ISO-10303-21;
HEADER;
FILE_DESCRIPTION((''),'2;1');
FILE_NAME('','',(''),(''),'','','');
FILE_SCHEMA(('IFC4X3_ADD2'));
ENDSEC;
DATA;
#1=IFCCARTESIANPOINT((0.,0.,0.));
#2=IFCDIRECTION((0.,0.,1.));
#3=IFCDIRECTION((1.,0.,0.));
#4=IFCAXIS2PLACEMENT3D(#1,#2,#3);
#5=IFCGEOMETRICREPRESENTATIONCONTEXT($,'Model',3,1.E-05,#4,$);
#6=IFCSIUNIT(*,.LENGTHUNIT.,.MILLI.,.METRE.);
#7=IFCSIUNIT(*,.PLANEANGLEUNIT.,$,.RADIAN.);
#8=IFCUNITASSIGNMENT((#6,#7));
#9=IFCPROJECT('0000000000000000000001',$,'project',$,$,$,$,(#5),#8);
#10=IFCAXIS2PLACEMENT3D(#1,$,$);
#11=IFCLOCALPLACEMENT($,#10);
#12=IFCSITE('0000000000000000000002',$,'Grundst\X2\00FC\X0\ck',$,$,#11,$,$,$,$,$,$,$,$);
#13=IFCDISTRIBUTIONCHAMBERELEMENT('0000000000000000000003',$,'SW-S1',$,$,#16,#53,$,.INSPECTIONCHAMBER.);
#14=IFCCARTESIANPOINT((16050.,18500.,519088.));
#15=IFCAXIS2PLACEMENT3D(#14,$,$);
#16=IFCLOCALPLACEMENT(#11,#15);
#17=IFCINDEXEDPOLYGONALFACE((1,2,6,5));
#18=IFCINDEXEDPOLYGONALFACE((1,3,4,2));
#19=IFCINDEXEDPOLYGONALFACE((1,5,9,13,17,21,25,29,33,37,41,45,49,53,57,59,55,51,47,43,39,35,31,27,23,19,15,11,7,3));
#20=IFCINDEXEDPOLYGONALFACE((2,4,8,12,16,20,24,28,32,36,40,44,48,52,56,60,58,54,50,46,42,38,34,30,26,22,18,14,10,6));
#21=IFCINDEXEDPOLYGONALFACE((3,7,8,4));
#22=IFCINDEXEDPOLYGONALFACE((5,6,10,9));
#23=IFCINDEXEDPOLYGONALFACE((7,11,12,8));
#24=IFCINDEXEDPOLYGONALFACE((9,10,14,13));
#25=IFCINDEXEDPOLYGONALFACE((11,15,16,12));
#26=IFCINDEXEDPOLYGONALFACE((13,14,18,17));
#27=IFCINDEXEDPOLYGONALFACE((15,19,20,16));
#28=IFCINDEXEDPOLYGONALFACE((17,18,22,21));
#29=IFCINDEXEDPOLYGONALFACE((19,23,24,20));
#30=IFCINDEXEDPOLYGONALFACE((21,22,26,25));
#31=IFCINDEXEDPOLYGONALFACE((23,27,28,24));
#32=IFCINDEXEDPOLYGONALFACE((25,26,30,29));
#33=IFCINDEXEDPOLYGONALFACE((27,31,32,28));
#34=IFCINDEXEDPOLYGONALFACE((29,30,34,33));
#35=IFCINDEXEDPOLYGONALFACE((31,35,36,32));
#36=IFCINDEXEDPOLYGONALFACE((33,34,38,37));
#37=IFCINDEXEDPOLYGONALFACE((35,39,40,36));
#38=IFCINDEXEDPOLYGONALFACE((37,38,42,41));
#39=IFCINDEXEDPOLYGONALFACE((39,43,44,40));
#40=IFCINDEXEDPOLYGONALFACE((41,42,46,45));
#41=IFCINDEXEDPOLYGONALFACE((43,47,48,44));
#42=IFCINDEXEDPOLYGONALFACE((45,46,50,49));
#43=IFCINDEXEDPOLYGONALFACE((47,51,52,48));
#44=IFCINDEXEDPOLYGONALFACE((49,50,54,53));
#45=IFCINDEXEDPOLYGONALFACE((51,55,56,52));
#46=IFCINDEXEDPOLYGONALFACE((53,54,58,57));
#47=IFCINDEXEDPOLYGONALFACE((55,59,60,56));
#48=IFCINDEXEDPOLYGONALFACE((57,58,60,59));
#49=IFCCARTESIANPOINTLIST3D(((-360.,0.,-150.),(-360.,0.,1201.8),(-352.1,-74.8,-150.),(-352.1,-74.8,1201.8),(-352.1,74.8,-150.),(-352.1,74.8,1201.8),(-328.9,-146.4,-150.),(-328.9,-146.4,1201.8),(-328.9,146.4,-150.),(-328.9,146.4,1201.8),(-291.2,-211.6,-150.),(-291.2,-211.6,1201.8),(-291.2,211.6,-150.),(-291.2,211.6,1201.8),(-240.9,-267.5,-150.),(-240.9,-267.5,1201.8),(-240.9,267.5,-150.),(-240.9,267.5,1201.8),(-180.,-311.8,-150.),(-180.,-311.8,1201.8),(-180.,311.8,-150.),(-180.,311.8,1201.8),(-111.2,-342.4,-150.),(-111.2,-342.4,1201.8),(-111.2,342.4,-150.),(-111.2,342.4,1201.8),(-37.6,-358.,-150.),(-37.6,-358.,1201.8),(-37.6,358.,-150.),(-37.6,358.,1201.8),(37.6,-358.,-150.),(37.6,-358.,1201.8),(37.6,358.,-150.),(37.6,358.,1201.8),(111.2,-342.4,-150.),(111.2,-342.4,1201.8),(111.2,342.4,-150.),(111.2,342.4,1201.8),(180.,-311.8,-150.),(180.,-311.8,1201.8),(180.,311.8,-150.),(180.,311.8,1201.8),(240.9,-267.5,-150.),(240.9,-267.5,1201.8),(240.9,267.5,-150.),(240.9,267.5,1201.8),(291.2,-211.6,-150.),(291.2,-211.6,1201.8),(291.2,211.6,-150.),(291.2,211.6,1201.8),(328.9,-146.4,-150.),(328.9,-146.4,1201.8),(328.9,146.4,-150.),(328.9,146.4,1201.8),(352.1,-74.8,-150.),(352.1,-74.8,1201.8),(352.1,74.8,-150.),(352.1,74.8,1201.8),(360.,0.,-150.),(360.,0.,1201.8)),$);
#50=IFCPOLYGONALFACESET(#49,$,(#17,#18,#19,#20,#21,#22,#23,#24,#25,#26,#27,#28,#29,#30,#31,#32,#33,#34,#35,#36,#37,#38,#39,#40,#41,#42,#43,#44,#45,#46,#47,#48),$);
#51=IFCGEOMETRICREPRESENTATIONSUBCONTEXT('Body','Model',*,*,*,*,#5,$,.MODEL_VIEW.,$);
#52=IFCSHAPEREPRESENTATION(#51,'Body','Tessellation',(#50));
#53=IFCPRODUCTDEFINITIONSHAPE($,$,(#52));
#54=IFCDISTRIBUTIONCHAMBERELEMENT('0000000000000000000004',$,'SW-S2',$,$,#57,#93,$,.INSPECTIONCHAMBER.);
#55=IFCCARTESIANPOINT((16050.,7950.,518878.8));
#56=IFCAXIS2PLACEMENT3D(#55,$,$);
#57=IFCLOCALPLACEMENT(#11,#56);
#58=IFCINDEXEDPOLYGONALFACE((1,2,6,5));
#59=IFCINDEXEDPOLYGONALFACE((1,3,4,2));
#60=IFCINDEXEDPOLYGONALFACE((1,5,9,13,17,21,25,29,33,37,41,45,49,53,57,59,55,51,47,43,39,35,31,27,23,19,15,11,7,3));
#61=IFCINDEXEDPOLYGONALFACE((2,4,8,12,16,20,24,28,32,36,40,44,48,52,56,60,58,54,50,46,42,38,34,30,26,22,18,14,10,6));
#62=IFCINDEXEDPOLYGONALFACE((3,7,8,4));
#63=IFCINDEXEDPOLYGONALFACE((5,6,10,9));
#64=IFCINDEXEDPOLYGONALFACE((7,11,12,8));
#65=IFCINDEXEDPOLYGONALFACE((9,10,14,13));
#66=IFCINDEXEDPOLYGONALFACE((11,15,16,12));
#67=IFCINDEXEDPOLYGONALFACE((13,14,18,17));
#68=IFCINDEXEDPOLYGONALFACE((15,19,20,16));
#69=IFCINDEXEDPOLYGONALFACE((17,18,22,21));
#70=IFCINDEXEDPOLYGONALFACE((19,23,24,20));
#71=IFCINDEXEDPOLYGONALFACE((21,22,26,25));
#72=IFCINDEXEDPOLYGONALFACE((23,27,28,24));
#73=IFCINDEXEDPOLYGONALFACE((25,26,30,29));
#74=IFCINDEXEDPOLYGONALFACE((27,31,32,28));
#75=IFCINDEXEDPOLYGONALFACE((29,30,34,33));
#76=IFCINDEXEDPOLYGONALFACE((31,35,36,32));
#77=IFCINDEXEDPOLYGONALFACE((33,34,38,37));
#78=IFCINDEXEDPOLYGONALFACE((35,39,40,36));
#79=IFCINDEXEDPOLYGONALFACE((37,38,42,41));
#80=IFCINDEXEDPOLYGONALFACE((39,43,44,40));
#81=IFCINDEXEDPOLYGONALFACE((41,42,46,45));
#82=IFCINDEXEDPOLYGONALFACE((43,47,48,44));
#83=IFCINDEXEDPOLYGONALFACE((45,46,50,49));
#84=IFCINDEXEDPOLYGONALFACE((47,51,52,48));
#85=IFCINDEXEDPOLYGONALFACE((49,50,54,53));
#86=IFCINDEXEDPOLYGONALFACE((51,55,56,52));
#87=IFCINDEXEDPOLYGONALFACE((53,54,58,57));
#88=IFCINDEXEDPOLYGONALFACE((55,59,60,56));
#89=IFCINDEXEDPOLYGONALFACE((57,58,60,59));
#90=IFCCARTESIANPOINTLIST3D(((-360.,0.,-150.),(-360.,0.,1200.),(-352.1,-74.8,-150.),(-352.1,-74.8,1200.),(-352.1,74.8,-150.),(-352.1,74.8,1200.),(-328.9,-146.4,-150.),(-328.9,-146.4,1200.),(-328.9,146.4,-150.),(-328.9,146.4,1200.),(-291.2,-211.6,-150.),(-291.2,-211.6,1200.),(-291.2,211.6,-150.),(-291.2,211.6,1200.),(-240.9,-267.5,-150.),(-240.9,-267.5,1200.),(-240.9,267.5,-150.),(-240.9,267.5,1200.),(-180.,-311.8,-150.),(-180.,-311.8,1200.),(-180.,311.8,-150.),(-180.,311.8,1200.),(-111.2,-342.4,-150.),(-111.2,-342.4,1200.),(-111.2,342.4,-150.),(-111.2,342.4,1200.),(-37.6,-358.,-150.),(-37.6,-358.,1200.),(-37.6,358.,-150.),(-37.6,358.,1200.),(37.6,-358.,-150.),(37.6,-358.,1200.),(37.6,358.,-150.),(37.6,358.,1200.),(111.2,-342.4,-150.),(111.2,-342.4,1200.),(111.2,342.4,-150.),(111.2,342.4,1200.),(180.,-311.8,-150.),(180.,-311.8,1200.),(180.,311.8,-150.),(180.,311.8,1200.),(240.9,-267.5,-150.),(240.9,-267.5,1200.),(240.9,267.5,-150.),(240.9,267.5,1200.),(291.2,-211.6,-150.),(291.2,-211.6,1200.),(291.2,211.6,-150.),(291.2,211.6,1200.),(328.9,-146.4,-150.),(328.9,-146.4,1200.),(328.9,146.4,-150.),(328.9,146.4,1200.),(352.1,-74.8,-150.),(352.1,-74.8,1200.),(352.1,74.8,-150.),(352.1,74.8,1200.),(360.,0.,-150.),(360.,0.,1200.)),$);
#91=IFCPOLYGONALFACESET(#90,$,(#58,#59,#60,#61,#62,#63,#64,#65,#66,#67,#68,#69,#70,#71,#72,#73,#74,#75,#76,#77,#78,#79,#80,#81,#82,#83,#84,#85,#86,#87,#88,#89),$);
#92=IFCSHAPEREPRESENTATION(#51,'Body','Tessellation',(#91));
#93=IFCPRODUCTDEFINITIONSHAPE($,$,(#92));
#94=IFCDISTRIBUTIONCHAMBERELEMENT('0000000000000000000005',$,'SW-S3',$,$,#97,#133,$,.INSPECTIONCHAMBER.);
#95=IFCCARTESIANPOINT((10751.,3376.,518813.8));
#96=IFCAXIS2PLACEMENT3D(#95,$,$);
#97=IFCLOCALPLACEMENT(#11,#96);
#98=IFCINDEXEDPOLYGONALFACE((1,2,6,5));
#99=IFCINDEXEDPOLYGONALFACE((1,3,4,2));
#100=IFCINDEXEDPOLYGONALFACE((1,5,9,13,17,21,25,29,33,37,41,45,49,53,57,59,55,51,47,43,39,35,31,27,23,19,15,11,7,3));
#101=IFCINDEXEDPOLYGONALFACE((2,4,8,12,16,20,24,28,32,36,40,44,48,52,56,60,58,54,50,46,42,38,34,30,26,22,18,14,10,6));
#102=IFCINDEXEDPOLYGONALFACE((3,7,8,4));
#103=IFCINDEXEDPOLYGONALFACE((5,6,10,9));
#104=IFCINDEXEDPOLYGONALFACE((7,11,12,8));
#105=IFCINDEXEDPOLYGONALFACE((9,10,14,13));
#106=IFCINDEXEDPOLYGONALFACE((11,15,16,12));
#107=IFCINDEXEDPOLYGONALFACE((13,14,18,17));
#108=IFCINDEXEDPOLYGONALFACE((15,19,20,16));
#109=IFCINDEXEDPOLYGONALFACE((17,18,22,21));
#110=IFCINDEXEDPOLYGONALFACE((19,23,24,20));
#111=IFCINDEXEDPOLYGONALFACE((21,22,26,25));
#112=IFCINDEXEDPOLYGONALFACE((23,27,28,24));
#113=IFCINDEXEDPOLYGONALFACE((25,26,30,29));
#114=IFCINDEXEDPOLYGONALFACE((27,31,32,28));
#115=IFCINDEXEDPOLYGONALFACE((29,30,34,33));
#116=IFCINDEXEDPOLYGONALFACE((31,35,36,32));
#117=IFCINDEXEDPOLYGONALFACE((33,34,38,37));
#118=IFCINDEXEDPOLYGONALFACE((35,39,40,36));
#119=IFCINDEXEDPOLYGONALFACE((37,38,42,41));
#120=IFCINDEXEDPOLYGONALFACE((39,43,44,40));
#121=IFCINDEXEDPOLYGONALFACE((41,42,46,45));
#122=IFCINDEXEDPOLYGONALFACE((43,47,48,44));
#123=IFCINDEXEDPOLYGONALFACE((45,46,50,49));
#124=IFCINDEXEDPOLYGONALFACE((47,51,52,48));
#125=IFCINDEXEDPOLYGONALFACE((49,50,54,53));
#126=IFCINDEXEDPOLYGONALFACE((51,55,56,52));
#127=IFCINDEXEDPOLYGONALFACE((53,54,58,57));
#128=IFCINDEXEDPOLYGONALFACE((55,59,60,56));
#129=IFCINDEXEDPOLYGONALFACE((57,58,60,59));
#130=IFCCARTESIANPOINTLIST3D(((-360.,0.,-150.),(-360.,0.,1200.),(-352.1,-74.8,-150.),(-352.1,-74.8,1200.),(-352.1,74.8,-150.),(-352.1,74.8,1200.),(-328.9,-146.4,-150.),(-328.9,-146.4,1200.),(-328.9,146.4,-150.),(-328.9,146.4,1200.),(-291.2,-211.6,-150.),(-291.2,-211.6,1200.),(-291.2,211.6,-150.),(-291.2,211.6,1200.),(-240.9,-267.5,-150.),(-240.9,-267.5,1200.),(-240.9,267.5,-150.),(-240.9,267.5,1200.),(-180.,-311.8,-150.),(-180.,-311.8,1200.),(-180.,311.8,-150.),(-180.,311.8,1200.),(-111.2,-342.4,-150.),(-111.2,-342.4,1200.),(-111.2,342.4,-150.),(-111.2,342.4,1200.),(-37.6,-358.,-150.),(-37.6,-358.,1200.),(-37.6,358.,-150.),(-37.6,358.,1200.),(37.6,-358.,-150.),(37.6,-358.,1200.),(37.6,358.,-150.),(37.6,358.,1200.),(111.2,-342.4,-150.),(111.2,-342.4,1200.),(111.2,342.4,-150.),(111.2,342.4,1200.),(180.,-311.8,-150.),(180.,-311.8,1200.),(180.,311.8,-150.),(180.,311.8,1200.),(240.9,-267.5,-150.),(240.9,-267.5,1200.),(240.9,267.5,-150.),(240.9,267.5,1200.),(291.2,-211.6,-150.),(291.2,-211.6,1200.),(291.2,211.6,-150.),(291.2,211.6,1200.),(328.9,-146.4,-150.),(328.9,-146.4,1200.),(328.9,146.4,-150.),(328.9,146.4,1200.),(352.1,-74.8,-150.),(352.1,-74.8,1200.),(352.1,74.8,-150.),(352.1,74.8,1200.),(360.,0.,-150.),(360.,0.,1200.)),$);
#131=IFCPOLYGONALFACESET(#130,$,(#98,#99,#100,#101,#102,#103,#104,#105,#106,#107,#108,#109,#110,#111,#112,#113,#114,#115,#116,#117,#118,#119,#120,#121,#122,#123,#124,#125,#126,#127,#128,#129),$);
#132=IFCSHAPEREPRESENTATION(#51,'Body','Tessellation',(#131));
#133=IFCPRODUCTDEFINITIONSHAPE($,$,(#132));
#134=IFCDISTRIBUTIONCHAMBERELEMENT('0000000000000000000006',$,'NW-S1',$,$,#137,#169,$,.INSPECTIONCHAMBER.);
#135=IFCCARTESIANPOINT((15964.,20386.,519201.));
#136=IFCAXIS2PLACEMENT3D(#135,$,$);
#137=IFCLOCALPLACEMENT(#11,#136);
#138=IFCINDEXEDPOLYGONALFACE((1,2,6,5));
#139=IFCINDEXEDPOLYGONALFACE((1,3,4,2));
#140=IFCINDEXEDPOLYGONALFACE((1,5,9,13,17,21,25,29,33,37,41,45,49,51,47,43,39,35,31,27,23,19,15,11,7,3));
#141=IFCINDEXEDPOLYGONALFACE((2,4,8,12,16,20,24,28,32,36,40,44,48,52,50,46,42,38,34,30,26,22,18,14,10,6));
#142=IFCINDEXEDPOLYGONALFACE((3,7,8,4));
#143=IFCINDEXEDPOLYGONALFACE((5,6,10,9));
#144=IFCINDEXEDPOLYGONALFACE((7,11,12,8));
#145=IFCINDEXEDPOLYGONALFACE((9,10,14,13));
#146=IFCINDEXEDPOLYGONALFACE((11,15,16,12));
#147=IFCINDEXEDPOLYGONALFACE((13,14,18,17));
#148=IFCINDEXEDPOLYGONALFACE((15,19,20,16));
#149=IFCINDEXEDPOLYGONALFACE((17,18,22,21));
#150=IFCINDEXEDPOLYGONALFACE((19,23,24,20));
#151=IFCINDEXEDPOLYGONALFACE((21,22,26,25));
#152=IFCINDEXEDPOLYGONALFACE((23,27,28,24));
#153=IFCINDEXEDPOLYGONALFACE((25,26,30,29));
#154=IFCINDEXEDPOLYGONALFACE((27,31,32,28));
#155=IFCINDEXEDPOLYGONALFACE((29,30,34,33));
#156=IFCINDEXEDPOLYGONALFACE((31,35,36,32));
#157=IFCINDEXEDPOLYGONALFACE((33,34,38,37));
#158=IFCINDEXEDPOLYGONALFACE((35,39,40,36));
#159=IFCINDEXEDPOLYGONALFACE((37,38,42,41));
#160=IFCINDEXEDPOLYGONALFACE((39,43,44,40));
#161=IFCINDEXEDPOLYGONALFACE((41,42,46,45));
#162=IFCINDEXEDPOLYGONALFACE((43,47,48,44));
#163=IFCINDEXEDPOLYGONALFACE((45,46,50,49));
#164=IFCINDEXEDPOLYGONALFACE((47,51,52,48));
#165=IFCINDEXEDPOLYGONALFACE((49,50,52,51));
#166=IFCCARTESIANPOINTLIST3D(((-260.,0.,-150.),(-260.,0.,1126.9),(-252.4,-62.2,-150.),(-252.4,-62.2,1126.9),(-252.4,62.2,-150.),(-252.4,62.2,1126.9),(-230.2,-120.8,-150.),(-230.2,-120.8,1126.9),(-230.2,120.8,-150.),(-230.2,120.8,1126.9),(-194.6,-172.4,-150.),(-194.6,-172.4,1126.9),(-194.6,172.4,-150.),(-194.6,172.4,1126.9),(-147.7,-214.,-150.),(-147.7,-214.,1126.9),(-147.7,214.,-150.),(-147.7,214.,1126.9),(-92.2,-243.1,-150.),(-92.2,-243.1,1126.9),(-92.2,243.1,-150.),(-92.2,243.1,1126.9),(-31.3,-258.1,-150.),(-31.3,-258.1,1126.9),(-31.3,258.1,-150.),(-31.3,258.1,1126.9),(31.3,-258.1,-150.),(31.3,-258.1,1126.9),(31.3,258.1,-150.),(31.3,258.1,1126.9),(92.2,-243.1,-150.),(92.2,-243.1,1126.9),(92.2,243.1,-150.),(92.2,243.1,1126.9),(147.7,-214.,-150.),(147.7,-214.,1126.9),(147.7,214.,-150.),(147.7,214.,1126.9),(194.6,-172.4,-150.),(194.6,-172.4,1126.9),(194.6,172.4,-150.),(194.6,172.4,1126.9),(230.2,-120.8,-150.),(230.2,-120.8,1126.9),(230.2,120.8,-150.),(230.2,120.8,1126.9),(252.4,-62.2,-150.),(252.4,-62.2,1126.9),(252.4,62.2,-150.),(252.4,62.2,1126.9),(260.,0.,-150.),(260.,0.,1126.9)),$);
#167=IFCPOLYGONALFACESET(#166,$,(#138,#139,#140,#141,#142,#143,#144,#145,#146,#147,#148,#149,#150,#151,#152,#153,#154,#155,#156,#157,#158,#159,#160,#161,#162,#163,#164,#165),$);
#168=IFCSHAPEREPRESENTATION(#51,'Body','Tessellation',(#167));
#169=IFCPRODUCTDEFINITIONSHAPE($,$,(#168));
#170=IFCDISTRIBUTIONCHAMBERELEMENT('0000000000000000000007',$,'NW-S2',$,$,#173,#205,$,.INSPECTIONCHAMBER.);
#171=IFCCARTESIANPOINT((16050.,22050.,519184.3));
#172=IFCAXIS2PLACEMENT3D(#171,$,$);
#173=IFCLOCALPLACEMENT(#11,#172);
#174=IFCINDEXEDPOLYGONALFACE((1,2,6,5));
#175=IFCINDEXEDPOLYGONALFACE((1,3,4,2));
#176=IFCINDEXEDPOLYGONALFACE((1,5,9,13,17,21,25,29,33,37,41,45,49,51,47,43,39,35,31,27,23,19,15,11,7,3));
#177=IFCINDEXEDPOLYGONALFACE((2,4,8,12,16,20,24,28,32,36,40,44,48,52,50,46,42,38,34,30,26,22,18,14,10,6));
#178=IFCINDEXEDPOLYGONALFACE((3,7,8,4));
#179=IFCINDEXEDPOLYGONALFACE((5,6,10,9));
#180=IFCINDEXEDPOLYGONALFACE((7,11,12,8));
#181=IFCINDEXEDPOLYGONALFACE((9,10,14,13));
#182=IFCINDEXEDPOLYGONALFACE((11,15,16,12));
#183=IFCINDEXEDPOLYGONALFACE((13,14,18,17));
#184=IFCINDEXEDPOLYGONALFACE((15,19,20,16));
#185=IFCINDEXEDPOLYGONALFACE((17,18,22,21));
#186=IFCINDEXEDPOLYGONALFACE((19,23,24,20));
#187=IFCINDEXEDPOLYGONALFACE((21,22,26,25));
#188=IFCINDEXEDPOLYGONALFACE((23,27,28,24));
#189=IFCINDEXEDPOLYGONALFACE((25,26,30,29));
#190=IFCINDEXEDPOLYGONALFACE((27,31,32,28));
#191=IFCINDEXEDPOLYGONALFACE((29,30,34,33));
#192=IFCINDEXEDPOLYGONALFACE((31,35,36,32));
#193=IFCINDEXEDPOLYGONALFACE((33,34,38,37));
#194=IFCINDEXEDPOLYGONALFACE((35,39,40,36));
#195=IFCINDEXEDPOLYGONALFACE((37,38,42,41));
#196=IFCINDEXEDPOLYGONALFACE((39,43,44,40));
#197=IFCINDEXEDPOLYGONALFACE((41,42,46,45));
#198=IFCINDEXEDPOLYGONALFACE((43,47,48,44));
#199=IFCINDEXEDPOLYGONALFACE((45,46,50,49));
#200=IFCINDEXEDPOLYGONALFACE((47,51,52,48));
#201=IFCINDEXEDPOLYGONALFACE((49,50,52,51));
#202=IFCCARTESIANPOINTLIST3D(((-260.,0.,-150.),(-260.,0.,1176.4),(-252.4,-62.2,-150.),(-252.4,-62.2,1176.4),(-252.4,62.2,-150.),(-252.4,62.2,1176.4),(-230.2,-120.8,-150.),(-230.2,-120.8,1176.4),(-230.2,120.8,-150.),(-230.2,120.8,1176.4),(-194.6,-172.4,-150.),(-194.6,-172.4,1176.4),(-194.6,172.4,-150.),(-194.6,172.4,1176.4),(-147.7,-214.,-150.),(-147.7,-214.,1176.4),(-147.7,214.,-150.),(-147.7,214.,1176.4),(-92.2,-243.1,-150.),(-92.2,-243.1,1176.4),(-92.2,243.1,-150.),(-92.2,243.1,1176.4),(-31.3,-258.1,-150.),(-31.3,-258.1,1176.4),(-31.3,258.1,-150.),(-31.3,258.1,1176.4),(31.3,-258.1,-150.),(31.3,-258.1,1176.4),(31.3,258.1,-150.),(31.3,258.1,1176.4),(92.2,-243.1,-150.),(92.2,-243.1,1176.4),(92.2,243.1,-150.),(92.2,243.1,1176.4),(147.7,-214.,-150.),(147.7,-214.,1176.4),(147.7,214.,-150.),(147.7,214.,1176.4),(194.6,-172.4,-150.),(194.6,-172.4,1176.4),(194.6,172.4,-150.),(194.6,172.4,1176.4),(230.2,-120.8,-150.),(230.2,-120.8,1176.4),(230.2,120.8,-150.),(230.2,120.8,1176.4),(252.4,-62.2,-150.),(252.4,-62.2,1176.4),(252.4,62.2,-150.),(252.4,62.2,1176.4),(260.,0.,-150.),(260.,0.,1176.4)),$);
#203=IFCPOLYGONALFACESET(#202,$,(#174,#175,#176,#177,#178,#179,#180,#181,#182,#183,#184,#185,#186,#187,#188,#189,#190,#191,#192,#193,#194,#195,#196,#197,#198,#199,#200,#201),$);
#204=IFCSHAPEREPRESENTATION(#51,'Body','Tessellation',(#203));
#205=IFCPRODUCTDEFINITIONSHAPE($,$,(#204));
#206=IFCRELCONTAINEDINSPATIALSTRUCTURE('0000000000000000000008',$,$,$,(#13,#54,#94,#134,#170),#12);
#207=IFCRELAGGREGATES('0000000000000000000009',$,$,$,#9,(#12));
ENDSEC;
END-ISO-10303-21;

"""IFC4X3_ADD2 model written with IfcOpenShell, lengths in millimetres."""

from ifc_helpers import new_model, si_unit, frame, origin, origin_with_axes, place, context, subcontext, project, spatial, circle, extrude, element, save


model = new_model("IFC4X3_ADD2")

# Units and contexts
model_context = context("Model", 3, precision=1e-05, world=origin_with_axes())
body_context = subcontext(model_context, "Body", "Model", "MODEL_VIEW")
ifc_project = project(units=[si_unit("LENGTHUNIT", "METRE", prefix="MILLI"), si_unit("PLANEANGLEUNIT", "RADIAN")], contexts=[model_context])

# Site
site_placement = place(None, origin())
site = spatial("IfcSite", under=ifc_project, at=site_placement, Name="Grundstück")

# Distribution chamber elements
distribution_chamber_element_1_placement = place(site_placement, frame((16050.0, 18500.0, 519088.0)))
element("IfcDistributionChamberElement", 1, at=distribution_chamber_element_1_placement, inside=site, Name="SW-S1", PredefinedType="INSPECTIONCHAMBER", context=body_context, shape_type="SweptSolid", body=[
    extrude(circle(Radius=360.0), frame((0.0, 0.0, -150.0)), (0.0, 0.0, 1.0), 1351.8),
])
for number, where, name in (
    (2, (16050.0, 7950.0, 518878.8), "SW-S2"),
    (3, (10751.0, 3376.0, 518813.8), "SW-S3"),
):
    element("IfcDistributionChamberElement", number, at=place(site_placement, frame(where)), inside=site, Name=name, PredefinedType="INSPECTIONCHAMBER", context=body_context, shape_type="SweptSolid", body=[
        extrude(circle(Radius=360.0), frame((0.0, 0.0, -150.0)), (0.0, 0.0, 1.0), 1350.0),
    ])

# Distribution chamber elements
distribution_chamber_element_2_placement = place(site_placement, frame((15964.0, 20386.0, 519201.0)))
element("IfcDistributionChamberElement", 4, at=distribution_chamber_element_2_placement, inside=site, Name="NW-S1", PredefinedType="INSPECTIONCHAMBER", context=body_context, shape_type="SweptSolid", body=[
    extrude(circle(Radius=260.0), frame((0.0, 0.0, -150.0)), (0.0, 0.0, 1.0), 1276.9),
])
distribution_chamber_element_3_placement = place(site_placement, frame((16050.0, 22050.0, 519184.3)))
element("IfcDistributionChamberElement", 5, at=distribution_chamber_element_3_placement, inside=site, Name="NW-S2", PredefinedType="INSPECTIONCHAMBER", context=body_context, shape_type="SweptSolid", body=[
    extrude(circle(Radius=260.0), frame((0.0, 0.0, -150.0)), (0.0, 0.0, 1.0), 1326.4),
])

save(model, "model.ifc")
